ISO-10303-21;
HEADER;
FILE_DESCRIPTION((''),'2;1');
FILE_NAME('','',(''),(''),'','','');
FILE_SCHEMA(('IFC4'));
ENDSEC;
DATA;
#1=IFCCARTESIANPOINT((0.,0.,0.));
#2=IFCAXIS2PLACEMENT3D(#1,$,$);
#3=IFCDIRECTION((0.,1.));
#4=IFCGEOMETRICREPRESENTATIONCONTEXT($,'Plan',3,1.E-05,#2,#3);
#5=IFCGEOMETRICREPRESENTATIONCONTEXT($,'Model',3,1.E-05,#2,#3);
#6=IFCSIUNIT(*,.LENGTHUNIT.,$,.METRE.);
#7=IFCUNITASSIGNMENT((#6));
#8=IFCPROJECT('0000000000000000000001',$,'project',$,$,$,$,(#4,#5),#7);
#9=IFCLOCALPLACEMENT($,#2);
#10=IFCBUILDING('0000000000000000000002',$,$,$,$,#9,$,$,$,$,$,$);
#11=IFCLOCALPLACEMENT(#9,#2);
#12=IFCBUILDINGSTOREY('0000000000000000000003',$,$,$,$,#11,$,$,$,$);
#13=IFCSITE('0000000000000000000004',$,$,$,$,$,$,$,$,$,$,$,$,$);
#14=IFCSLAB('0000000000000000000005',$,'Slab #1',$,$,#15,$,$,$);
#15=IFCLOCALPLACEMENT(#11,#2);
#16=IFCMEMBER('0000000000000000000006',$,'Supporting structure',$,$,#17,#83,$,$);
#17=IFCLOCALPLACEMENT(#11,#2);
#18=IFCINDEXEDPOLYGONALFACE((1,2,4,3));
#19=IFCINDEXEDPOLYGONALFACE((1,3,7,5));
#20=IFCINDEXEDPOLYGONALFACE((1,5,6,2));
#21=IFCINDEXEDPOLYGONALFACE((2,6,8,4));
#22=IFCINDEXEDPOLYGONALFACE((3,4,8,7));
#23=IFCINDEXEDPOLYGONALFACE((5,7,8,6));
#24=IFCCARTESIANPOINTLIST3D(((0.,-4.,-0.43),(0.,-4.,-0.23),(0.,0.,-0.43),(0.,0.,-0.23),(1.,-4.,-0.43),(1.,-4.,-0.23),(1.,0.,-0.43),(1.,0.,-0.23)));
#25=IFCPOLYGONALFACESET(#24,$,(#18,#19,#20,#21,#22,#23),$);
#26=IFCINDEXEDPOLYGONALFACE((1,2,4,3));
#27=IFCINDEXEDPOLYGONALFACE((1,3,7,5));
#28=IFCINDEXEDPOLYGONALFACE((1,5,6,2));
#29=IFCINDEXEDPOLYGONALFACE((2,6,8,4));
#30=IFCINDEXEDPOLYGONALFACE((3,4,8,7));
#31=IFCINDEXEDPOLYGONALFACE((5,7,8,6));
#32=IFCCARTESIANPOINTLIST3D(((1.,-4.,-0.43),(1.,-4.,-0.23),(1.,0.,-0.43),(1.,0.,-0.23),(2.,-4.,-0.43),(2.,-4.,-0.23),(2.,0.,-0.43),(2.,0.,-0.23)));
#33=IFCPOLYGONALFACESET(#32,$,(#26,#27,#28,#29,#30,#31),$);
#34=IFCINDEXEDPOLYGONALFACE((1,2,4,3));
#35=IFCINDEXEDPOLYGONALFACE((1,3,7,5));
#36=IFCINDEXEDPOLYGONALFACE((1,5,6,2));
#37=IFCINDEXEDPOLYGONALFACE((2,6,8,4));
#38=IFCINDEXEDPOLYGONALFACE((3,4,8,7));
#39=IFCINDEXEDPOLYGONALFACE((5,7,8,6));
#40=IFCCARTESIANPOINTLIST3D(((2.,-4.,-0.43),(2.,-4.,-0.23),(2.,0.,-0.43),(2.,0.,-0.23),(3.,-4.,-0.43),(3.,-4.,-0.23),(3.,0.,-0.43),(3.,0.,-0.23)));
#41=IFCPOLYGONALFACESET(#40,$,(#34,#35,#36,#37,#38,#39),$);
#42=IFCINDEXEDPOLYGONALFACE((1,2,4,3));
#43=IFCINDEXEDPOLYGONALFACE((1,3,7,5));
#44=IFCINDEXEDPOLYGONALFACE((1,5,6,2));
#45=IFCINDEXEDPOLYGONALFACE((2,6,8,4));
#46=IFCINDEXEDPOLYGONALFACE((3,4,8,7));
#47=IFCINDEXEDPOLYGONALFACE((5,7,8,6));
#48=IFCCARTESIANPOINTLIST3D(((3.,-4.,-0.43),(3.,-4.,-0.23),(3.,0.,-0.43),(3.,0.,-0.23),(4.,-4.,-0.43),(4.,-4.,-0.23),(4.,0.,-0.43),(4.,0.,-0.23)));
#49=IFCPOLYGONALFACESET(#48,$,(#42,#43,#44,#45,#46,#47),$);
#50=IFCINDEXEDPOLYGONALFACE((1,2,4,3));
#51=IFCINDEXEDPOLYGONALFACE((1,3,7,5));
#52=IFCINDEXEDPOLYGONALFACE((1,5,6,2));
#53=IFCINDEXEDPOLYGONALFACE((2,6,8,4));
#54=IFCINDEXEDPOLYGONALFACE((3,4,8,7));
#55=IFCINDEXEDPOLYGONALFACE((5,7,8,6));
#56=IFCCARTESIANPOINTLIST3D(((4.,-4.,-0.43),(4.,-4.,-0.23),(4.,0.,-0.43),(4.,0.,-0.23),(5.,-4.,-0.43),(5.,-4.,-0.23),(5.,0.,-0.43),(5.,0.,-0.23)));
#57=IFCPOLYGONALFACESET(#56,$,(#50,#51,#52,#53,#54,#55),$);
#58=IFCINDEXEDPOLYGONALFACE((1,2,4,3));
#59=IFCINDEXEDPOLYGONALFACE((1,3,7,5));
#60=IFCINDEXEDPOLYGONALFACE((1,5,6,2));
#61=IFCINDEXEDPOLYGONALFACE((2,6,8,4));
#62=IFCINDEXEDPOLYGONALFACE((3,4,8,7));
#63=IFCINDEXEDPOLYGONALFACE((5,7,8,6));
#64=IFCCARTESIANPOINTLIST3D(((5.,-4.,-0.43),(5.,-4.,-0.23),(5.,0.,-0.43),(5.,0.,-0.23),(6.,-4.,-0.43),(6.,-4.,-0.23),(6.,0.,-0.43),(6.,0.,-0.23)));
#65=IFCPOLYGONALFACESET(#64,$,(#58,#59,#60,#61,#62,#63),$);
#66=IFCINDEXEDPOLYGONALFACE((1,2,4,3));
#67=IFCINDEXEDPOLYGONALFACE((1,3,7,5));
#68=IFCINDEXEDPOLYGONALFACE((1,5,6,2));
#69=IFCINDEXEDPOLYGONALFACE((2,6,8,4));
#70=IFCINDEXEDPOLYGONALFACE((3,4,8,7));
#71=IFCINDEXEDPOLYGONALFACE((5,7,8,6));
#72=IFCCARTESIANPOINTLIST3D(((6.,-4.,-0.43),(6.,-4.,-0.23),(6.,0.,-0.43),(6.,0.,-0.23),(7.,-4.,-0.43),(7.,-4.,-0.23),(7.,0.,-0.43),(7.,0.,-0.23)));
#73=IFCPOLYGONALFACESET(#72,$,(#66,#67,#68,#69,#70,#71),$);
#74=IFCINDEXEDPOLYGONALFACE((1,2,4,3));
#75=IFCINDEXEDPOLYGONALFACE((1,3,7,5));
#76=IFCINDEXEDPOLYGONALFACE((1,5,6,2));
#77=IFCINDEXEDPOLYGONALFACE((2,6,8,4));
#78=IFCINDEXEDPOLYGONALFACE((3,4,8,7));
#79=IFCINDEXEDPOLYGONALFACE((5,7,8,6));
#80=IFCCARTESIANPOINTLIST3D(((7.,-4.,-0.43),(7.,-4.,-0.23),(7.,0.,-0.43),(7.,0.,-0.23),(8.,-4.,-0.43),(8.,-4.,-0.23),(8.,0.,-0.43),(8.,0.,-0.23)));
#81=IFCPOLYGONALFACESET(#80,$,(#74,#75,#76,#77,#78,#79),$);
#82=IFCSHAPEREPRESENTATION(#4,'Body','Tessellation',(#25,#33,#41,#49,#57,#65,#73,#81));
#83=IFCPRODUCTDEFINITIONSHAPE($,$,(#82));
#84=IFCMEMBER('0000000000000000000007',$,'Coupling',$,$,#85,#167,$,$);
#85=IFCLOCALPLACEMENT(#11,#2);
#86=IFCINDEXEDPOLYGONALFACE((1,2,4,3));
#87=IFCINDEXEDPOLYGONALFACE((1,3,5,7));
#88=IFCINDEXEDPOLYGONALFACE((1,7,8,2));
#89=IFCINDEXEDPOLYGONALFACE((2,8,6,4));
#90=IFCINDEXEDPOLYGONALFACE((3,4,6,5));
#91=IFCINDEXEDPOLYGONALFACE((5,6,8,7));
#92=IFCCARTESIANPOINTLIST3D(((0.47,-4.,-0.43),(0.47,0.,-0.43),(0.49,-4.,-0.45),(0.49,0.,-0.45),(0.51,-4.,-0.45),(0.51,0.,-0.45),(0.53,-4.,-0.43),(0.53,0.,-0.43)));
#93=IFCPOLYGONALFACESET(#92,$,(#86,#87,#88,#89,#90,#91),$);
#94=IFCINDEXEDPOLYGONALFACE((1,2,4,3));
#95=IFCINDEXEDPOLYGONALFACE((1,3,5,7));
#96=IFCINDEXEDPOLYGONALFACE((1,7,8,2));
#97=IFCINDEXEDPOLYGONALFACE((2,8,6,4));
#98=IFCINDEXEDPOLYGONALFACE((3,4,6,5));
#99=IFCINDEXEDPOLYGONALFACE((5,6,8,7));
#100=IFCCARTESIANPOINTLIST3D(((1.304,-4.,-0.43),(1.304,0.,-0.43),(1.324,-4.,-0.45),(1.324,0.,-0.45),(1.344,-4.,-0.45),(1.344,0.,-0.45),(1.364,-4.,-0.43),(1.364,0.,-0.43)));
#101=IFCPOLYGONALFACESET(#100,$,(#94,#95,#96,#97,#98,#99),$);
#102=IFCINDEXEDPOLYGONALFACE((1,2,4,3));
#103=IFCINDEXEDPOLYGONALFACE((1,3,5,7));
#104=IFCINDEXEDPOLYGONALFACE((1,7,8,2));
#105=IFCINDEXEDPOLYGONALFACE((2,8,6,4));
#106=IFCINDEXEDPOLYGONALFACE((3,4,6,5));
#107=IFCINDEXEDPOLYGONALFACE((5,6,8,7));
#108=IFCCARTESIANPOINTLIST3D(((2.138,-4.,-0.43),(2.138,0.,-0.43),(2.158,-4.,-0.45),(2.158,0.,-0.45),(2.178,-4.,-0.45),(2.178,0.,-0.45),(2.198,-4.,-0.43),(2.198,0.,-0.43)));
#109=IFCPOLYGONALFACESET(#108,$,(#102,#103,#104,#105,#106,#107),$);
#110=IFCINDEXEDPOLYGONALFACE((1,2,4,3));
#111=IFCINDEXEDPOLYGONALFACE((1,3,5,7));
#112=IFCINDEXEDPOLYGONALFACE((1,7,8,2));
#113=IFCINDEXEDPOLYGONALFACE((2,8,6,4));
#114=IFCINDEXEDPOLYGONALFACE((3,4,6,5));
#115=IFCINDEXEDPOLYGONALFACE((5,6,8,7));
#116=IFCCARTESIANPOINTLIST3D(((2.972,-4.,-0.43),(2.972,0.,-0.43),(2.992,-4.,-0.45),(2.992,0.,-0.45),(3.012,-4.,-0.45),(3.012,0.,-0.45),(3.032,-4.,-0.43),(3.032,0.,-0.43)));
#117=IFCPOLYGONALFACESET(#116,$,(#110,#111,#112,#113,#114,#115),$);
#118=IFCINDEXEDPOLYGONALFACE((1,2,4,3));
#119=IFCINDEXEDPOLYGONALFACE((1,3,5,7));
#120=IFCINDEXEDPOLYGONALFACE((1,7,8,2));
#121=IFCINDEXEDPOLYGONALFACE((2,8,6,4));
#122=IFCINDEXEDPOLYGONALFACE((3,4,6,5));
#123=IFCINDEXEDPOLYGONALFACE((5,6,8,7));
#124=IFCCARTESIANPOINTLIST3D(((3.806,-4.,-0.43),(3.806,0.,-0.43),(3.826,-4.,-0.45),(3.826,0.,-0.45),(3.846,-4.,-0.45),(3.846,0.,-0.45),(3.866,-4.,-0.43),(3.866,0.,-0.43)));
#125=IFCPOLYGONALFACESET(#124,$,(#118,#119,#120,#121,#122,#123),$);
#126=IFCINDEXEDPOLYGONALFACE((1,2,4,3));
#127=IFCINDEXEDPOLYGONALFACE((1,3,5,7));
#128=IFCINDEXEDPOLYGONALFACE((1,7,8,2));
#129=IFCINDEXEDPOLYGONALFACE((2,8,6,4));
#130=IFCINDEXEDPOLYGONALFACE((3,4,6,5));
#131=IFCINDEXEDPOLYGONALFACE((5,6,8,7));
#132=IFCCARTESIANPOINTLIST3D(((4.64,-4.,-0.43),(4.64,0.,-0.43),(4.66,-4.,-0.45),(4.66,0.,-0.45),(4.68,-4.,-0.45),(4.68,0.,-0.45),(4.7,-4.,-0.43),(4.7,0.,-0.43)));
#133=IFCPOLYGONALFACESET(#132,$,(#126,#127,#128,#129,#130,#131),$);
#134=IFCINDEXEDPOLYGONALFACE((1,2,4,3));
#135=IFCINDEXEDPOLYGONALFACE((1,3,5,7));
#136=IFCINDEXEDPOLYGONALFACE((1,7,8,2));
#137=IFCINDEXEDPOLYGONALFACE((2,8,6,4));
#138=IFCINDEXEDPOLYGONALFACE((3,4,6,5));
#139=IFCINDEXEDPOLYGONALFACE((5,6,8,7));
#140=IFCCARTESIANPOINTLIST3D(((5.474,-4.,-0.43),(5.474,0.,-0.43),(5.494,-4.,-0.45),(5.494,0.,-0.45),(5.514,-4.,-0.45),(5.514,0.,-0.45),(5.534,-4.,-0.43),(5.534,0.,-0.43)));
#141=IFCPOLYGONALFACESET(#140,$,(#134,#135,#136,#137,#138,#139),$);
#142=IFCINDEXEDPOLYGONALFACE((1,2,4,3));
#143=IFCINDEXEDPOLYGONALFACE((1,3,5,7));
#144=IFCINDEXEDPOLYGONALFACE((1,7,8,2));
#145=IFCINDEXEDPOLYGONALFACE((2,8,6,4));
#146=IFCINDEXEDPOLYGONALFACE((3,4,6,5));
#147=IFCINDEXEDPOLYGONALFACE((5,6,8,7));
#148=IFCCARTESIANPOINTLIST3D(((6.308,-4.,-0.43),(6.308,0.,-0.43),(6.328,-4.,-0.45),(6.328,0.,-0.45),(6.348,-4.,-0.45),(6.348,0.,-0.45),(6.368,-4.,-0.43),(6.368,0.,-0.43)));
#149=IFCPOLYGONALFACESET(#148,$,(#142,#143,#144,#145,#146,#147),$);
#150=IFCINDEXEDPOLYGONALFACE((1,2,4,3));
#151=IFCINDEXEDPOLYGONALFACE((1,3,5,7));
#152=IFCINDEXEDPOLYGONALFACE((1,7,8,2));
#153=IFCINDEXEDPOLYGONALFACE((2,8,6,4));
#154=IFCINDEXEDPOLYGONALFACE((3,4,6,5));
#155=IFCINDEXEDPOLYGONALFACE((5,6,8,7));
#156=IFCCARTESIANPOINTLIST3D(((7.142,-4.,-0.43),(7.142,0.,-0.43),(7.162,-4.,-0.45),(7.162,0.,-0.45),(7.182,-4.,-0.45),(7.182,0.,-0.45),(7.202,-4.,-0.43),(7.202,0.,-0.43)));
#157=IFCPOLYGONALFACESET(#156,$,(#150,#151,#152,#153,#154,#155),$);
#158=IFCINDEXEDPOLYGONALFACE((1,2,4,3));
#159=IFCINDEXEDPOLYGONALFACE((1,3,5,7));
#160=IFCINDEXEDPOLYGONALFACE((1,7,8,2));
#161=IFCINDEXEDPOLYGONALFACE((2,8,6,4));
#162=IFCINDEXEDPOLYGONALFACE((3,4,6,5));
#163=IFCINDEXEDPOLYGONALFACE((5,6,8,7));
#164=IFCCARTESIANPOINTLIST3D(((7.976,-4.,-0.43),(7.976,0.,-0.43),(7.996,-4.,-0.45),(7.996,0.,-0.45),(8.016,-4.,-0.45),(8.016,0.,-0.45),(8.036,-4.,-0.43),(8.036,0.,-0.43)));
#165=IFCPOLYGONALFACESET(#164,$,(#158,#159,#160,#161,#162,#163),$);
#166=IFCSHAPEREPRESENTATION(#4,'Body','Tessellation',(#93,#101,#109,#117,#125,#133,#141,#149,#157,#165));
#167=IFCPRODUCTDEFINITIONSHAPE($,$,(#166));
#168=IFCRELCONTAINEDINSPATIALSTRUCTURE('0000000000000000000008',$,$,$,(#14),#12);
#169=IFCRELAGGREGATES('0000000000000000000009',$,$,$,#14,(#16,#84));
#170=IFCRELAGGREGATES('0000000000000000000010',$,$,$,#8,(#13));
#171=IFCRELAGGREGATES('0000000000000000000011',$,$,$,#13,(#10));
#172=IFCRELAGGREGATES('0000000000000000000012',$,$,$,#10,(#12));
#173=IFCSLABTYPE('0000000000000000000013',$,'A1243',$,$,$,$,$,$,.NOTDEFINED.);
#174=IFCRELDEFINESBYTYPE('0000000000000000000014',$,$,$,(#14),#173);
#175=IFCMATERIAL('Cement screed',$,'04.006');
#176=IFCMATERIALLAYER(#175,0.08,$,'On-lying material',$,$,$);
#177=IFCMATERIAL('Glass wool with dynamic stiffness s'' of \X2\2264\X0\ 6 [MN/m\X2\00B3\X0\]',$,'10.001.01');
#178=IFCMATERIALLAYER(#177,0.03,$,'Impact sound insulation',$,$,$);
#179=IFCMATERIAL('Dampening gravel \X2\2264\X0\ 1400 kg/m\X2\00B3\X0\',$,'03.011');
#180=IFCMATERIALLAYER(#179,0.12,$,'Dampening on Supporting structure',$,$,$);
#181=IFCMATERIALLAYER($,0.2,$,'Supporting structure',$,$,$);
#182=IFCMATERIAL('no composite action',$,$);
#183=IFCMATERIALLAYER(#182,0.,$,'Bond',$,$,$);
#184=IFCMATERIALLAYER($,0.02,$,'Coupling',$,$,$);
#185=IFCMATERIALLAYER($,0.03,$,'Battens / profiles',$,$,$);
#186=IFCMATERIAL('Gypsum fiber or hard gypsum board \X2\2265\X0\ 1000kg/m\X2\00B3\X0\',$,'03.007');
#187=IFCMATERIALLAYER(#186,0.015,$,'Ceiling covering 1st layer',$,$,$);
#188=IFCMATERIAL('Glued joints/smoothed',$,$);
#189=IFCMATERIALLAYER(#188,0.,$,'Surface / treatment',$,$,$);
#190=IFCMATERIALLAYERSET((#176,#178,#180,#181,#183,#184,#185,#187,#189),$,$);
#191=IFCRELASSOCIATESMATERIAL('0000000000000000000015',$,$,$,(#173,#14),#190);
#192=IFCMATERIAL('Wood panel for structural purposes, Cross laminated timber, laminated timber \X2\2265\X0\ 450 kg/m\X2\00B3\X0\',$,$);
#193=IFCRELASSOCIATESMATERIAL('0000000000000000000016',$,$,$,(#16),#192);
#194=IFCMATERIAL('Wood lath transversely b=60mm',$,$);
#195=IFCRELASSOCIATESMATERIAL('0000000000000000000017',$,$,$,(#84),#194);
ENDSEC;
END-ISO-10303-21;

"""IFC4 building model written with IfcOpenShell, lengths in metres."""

from ifc_helpers import new_model, si_unit, direction, frame, frame_2d, origin, place, context, project, spatial, polyline, rectangle, outline, extrude, material, layer, layer_set, type_object, element, aggregate, save


model = new_model("IFC4")

# Units and contexts
plan_context = context("Plan", 3, precision=1e-05, world=origin(), true_north=direction((0.0, 1.0)))
model_context = context("Model", 3, precision=1e-05, world=origin(), true_north=direction((0.0, 1.0)))
ifc_project = project(units=[si_unit("LENGTHUNIT", "METRE")], contexts=[plan_context, model_context])

# Site, building, storey
site = spatial("IfcSite", under=ifc_project)
building_placement = place(None, origin())
building = spatial("IfcBuilding", under=site, at=building_placement)
storey_placement = place(building_placement, origin())
storey = spatial("IfcBuildingStorey", under=building, at=storey_placement)

# Slab, members
ifc_material_1 = material(Name="Cement screed", Category="04.006")
ifc_layer_1 = layer(ifc_material_1, 0.08, Name="On-lying material")
ifc_material_2 = material(Name="Glass wool with dynamic stiffness s' of ≤ 6 [MN/m³]", Category="10.001.01")
ifc_layer_2 = layer(ifc_material_2, 0.03, Name="Impact sound insulation")
ifc_material_3 = material(Name="Dampening gravel ≤ 1400 kg/m³", Category="03.011")
ifc_layer_3 = layer(ifc_material_3, 0.12, Name="Dampening on Supporting structure")
ifc_layer_4 = layer(None, 0.2, Name="Supporting structure")
ifc_material_4 = material(Name="no composite action")
ifc_layer_5 = layer(ifc_material_4, 0.0, Name="Bond")
ifc_layer_6 = layer(None, 0.02, Name="Coupling")
ifc_layer_7 = layer(None, 0.03, Name="Battens / profiles")
ifc_material_5 = material(Name="Gypsum fiber or hard gypsum board ≥ 1000kg/m³", Category="03.007")
ifc_layer_8 = layer(ifc_material_5, 0.015, Name="Ceiling covering 1st layer")
ifc_material_6 = material(Name="Glued joints/smoothed")
ifc_layer_9 = layer(ifc_material_6, 0.0, Name="Surface / treatment")
ifc_layer_set = layer_set([ifc_layer_1, ifc_layer_2, ifc_layer_3, ifc_layer_4, ifc_layer_5, ifc_layer_6, ifc_layer_7, ifc_layer_8, ifc_layer_9])
slab_type = type_object("IfcSlabType", Name="A1243", PredefinedType="NOTDEFINED", material=ifc_layer_set)
slab_placement = place(None, frame((0.0, 0.0, 0.0), z_axis=(0.0, 0.0, -1.0), x_axis=(1.0, 0.0, 0.0)))
slab = element("IfcSlab", 1, at=slab_placement, inside=storey, type_object=slab_type, material=ifc_layer_set, Name="Slab #1")
ifc_material_7 = material(Name="Wood panel for structural purposes, Cross laminated timber, laminated timber ≥ 450 kg/m³")
member_1_placement = place(slab_placement, origin())
member_1 = element("IfcMember", 2, at=member_1_placement, material=ifc_material_7, Name="Supporting structure", context=plan_context, shape_type="SweptSolid", body=[
    extrude(rectangle(XDim=1.0, YDim=0.2, at=frame_2d((0.5, 0.1), x_axis=(1.0, 0.0))), frame((0.0, 4.0, 0.23), z_axis=(0.0, -1.0, 0.0), x_axis=(1.0, 0.0, 0.0)), (0.0, 0.0, 1.0), 4.0),
    extrude(rectangle(XDim=1.0, YDim=0.2, at=frame_2d((0.5, 0.1), x_axis=(1.0, 0.0))), frame((1.0, 4.0, 0.23), z_axis=(0.0, -1.0, 0.0), x_axis=(1.0, 0.0, 0.0)), (0.0, 0.0, 1.0), 4.0),
    extrude(rectangle(XDim=1.0, YDim=0.2, at=frame_2d((0.5, 0.1), x_axis=(1.0, 0.0))), frame((2.0, 4.0, 0.23), z_axis=(0.0, -1.0, 0.0), x_axis=(1.0, 0.0, 0.0)), (0.0, 0.0, 1.0), 4.0),
    extrude(rectangle(XDim=1.0, YDim=0.2, at=frame_2d((0.5, 0.1), x_axis=(1.0, 0.0))), frame((3.0, 4.0, 0.23), z_axis=(0.0, -1.0, 0.0), x_axis=(1.0, 0.0, 0.0)), (0.0, 0.0, 1.0), 4.0),
    extrude(rectangle(XDim=1.0, YDim=0.2, at=frame_2d((0.5, 0.1), x_axis=(1.0, 0.0))), frame((4.0, 4.0, 0.23), z_axis=(0.0, -1.0, 0.0), x_axis=(1.0, 0.0, 0.0)), (0.0, 0.0, 1.0), 4.0),
    extrude(rectangle(XDim=1.0, YDim=0.2, at=frame_2d((0.5, 0.1), x_axis=(1.0, 0.0))), frame((5.0, 4.0, 0.23), z_axis=(0.0, -1.0, 0.0), x_axis=(1.0, 0.0, 0.0)), (0.0, 0.0, 1.0), 4.0),
    extrude(rectangle(XDim=1.0, YDim=0.2, at=frame_2d((0.5, 0.1), x_axis=(1.0, 0.0))), frame((6.0, 4.0, 0.23), z_axis=(0.0, -1.0, 0.0), x_axis=(1.0, 0.0, 0.0)), (0.0, 0.0, 1.0), 4.0),
    extrude(rectangle(XDim=1.0, YDim=0.2, at=frame_2d((0.5, 0.1), x_axis=(1.0, 0.0))), frame((7.0, 4.0, 0.23), z_axis=(0.0, -1.0, 0.0), x_axis=(1.0, 0.0, 0.0)), (0.0, 0.0, 1.0), 4.0),
])
ifc_material_8 = material(Name="Wood lath transversely b=60mm")
member_2_placement = place(slab_placement, origin())
member_2 = element("IfcMember", 3, at=member_2_placement, material=ifc_material_8, Name="Coupling", context=plan_context, shape_type="SweptSolid", body=[
    extrude(outline(polyline([(0.0, 0.0), (0.06, 0.0), (0.04, 0.02), (0.02, 0.02), (0.0, 0.0)])), frame((0.47, 4.0, 0.43), z_axis=(0.0, -1.0, 0.0), x_axis=(1.0, 0.0, 0.0)), (0.0, 0.0, 1.0), 4.0),
    extrude(outline(polyline([(0.0, 0.0), (0.06, 0.0), (0.04, 0.02), (0.02, 0.02), (0.0, 0.0)])), frame((1.304, 4.0, 0.43), z_axis=(0.0, -1.0, 0.0), x_axis=(1.0, 0.0, 0.0)), (0.0, 0.0, 1.0), 4.0),
    extrude(outline(polyline([(0.0, 0.0), (0.06, 0.0), (0.04, 0.02), (0.02, 0.02), (0.0, 0.0)])), frame((2.138, 4.0, 0.43), z_axis=(0.0, -1.0, 0.0), x_axis=(1.0, 0.0, 0.0)), (0.0, 0.0, 1.0), 4.0),
    extrude(outline(polyline([(0.0, 0.0), (0.06, 0.0), (0.04, 0.02), (0.02, 0.02), (0.0, 0.0)])), frame((2.972, 4.0, 0.43), z_axis=(0.0, -1.0, 0.0), x_axis=(1.0, 0.0, 0.0)), (0.0, 0.0, 1.0), 4.0),
    extrude(outline(polyline([(0.0, 0.0), (0.06, 0.0), (0.04, 0.02), (0.02, 0.02), (0.0, 0.0)])), frame((3.806, 4.0, 0.43), z_axis=(0.0, -1.0, 0.0), x_axis=(1.0, 0.0, 0.0)), (0.0, 0.0, 1.0), 4.0),
    extrude(outline(polyline([(0.0, 0.0), (0.06, 0.0), (0.04, 0.02), (0.02, 0.02), (0.0, 0.0)])), frame((4.64, 4.0, 0.43), z_axis=(0.0, -1.0, 0.0), x_axis=(1.0, 0.0, 0.0)), (0.0, 0.0, 1.0), 4.0),
    extrude(outline(polyline([(0.0, 0.0), (0.06, 0.0), (0.04, 0.02), (0.02, 0.02), (0.0, 0.0)])), frame((5.474, 4.0, 0.43), z_axis=(0.0, -1.0, 0.0), x_axis=(1.0, 0.0, 0.0)), (0.0, 0.0, 1.0), 4.0),
    extrude(outline(polyline([(0.0, 0.0), (0.06, 0.0), (0.04, 0.02), (0.02, 0.02), (0.0, 0.0)])), frame((6.308, 4.0, 0.43), z_axis=(0.0, -1.0, 0.0), x_axis=(1.0, 0.0, 0.0)), (0.0, 0.0, 1.0), 4.0),
    extrude(outline(polyline([(0.0, 0.0), (0.06, 0.0), (0.04, 0.02), (0.02, 0.02), (0.0, 0.0)])), frame((7.142, 4.0, 0.43), z_axis=(0.0, -1.0, 0.0), x_axis=(1.0, 0.0, 0.0)), (0.0, 0.0, 1.0), 4.0),
    extrude(outline(polyline([(0.0, 0.0), (0.06, 0.0), (0.04, 0.02), (0.02, 0.02), (0.0, 0.0)])), frame((7.976, 4.0, 0.43), z_axis=(0.0, -1.0, 0.0), x_axis=(1.0, 0.0, 0.0)), (0.0, 0.0, 1.0), 4.0),
])
aggregate(slab, [member_1, member_2])

save(model, "model.ifc")
